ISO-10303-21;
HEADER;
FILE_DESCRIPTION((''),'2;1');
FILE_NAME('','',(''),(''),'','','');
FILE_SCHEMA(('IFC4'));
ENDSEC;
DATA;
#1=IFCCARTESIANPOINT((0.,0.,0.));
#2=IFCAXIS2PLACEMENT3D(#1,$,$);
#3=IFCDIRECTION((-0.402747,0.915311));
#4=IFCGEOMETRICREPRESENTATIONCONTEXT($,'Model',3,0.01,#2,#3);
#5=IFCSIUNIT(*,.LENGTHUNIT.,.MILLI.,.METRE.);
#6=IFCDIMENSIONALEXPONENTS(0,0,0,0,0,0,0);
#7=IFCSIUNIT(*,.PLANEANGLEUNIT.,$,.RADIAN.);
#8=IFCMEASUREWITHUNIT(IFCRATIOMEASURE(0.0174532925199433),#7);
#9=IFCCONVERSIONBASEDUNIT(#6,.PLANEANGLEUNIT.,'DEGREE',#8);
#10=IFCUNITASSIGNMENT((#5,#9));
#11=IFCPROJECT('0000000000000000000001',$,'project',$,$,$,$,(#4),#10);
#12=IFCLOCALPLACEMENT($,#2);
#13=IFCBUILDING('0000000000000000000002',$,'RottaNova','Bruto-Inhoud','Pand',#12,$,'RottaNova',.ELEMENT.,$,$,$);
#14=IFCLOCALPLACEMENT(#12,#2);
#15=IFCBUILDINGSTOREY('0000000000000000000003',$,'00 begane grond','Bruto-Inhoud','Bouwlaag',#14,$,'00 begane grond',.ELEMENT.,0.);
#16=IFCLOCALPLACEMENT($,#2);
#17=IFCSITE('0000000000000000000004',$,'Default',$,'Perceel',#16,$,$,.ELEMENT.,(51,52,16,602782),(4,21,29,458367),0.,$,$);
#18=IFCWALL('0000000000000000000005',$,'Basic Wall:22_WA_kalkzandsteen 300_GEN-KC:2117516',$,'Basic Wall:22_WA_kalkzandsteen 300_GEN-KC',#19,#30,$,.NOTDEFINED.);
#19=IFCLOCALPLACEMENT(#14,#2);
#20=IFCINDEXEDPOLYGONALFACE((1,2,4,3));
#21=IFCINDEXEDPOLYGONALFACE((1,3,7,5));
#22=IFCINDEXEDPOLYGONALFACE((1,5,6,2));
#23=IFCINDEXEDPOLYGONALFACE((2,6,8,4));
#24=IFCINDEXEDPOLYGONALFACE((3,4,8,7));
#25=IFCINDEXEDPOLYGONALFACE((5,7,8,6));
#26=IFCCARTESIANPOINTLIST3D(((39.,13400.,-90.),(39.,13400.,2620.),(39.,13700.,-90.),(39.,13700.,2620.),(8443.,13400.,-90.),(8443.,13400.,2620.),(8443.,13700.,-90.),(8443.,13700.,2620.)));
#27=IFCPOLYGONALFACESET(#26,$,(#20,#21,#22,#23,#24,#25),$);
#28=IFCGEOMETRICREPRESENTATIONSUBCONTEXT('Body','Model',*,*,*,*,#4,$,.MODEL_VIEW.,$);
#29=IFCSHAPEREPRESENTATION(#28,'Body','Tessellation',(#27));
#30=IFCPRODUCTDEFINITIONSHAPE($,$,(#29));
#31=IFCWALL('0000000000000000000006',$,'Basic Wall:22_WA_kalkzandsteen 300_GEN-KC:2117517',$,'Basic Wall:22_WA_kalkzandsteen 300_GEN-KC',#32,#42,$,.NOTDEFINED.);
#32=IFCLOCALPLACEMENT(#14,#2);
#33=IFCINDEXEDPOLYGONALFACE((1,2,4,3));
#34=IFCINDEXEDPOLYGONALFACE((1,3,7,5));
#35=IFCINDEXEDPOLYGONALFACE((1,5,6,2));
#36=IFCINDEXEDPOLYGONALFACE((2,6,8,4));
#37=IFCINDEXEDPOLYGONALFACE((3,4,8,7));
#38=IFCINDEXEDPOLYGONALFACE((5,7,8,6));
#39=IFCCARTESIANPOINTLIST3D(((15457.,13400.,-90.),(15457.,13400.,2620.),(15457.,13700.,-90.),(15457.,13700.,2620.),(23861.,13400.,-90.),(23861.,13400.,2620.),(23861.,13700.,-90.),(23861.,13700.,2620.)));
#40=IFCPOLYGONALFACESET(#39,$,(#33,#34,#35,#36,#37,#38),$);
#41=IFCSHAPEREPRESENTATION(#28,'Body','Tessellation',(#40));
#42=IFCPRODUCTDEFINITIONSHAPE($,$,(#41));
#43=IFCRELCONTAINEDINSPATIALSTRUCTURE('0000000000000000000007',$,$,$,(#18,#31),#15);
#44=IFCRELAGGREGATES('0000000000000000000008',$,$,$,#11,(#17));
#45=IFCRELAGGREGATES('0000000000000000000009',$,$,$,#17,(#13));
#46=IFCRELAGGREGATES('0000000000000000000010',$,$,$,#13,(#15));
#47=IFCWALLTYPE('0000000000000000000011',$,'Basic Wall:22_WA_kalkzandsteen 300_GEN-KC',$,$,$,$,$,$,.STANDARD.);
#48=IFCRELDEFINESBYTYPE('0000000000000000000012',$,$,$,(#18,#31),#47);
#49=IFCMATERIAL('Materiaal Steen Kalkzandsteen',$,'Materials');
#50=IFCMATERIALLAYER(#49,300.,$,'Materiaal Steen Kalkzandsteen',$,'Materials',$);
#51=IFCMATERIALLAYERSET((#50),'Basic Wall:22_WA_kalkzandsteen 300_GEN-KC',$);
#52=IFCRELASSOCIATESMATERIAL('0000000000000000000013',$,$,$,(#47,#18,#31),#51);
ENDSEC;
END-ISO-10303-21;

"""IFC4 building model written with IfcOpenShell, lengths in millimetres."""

from ifc_helpers import new_model, entity, si_unit, converted_unit, direction, frame, frame_2d, origin, place, context, subcontext, project, spatial, rectangle, extrude, material, layer, layer_set, type_object, element, save


model = new_model("IFC4")

# Units and contexts
model_context = context("Model", 3, precision=0.01, world=origin(), true_north=direction((-0.402747, 0.915311)))
body_context = subcontext(model_context, "Body", "Model", "MODEL_VIEW")
ifc_project = project(units=[si_unit("LENGTHUNIT", "METRE", prefix="MILLI"), converted_unit("PLANEANGLEUNIT", "DEGREE", entity("IfcRatioMeasure", 0.0174532925199433), si_unit("PLANEANGLEUNIT", "RADIAN"), dimensions=[0, 0, 0, 0, 0, 0, 0])], contexts=[model_context])

# Site, building, storey
site_placement = place(None, origin())
site = spatial("IfcSite", under=ifc_project, at=site_placement, Name="Default", ObjectType="Perceel", CompositionType="ELEMENT", RefLatitude=(51, 52, 16, 602782), RefLongitude=(4, 21, 29, 458367), RefElevation=0.0)
building_placement = place(None, origin())
building = spatial("IfcBuilding", under=site, at=building_placement, Name="RottaNova", Description="Bruto-Inhoud", ObjectType="Pand", LongName="RottaNova", CompositionType="ELEMENT")
storey_placement = place(building_placement, origin())
storey = spatial("IfcBuildingStorey", under=building, at=storey_placement, Name="00 begane grond", Description="Bruto-Inhoud", ObjectType="Bouwlaag", LongName="00 begane grond", CompositionType="ELEMENT", Elevation=0.0)

# Walls
ifc_material_1 = material(Name="Materiaal Steen Kalkzandsteen", Category="Materials")
ifc_layer_1 = layer(ifc_material_1, 300.0, Name="Materiaal Steen Kalkzandsteen", Category="Materials")
ifc_layer_set_1 = layer_set([ifc_layer_1], Name="Basic Wall:22_WA_kalkzandsteen 300_GEN-KC")
wall_type_1 = type_object("IfcWallType", Name="Basic Wall:22_WA_kalkzandsteen 300_GEN-KC", PredefinedType="STANDARD", material=ifc_layer_set_1)
wall_1_placement = place(storey_placement, frame((39.0, 13550.0, -90.0)))
element("IfcWall", 1, at=wall_1_placement, inside=storey, type_object=wall_type_1, material=ifc_layer_set_1, Name="Basic Wall:22_WA_kalkzandsteen 300_GEN-KC:2117516", ObjectType="Basic Wall:22_WA_kalkzandsteen 300_GEN-KC", PredefinedType="NOTDEFINED", context=body_context, shape_type="SweptSolid", body=[
    extrude(rectangle(XDim=8404.0, YDim=300.0, at=frame_2d((4202.0, 0.0), x_axis=(-1.0, 0.0))), origin(), (0.0, 0.0, 1.0), 2710.0),
])
wall_2_placement = place(storey_placement, frame((15457.0, 13550.0, -90.0)))
element("IfcWall", 2, at=wall_2_placement, inside=storey, type_object=wall_type_1, material=ifc_layer_set_1, Name="Basic Wall:22_WA_kalkzandsteen 300_GEN-KC:2117517", ObjectType="Basic Wall:22_WA_kalkzandsteen 300_GEN-KC", PredefinedType="NOTDEFINED", context=body_context, shape_type="SweptSolid", body=[
    extrude(rectangle(XDim=8404.0, YDim=300.0, at=frame_2d((4202.0, 0.0), x_axis=(-1.0, 0.0))), origin(), (0.0, 0.0, 1.0), 2710.0),
])

save(model, "model.ifc")
